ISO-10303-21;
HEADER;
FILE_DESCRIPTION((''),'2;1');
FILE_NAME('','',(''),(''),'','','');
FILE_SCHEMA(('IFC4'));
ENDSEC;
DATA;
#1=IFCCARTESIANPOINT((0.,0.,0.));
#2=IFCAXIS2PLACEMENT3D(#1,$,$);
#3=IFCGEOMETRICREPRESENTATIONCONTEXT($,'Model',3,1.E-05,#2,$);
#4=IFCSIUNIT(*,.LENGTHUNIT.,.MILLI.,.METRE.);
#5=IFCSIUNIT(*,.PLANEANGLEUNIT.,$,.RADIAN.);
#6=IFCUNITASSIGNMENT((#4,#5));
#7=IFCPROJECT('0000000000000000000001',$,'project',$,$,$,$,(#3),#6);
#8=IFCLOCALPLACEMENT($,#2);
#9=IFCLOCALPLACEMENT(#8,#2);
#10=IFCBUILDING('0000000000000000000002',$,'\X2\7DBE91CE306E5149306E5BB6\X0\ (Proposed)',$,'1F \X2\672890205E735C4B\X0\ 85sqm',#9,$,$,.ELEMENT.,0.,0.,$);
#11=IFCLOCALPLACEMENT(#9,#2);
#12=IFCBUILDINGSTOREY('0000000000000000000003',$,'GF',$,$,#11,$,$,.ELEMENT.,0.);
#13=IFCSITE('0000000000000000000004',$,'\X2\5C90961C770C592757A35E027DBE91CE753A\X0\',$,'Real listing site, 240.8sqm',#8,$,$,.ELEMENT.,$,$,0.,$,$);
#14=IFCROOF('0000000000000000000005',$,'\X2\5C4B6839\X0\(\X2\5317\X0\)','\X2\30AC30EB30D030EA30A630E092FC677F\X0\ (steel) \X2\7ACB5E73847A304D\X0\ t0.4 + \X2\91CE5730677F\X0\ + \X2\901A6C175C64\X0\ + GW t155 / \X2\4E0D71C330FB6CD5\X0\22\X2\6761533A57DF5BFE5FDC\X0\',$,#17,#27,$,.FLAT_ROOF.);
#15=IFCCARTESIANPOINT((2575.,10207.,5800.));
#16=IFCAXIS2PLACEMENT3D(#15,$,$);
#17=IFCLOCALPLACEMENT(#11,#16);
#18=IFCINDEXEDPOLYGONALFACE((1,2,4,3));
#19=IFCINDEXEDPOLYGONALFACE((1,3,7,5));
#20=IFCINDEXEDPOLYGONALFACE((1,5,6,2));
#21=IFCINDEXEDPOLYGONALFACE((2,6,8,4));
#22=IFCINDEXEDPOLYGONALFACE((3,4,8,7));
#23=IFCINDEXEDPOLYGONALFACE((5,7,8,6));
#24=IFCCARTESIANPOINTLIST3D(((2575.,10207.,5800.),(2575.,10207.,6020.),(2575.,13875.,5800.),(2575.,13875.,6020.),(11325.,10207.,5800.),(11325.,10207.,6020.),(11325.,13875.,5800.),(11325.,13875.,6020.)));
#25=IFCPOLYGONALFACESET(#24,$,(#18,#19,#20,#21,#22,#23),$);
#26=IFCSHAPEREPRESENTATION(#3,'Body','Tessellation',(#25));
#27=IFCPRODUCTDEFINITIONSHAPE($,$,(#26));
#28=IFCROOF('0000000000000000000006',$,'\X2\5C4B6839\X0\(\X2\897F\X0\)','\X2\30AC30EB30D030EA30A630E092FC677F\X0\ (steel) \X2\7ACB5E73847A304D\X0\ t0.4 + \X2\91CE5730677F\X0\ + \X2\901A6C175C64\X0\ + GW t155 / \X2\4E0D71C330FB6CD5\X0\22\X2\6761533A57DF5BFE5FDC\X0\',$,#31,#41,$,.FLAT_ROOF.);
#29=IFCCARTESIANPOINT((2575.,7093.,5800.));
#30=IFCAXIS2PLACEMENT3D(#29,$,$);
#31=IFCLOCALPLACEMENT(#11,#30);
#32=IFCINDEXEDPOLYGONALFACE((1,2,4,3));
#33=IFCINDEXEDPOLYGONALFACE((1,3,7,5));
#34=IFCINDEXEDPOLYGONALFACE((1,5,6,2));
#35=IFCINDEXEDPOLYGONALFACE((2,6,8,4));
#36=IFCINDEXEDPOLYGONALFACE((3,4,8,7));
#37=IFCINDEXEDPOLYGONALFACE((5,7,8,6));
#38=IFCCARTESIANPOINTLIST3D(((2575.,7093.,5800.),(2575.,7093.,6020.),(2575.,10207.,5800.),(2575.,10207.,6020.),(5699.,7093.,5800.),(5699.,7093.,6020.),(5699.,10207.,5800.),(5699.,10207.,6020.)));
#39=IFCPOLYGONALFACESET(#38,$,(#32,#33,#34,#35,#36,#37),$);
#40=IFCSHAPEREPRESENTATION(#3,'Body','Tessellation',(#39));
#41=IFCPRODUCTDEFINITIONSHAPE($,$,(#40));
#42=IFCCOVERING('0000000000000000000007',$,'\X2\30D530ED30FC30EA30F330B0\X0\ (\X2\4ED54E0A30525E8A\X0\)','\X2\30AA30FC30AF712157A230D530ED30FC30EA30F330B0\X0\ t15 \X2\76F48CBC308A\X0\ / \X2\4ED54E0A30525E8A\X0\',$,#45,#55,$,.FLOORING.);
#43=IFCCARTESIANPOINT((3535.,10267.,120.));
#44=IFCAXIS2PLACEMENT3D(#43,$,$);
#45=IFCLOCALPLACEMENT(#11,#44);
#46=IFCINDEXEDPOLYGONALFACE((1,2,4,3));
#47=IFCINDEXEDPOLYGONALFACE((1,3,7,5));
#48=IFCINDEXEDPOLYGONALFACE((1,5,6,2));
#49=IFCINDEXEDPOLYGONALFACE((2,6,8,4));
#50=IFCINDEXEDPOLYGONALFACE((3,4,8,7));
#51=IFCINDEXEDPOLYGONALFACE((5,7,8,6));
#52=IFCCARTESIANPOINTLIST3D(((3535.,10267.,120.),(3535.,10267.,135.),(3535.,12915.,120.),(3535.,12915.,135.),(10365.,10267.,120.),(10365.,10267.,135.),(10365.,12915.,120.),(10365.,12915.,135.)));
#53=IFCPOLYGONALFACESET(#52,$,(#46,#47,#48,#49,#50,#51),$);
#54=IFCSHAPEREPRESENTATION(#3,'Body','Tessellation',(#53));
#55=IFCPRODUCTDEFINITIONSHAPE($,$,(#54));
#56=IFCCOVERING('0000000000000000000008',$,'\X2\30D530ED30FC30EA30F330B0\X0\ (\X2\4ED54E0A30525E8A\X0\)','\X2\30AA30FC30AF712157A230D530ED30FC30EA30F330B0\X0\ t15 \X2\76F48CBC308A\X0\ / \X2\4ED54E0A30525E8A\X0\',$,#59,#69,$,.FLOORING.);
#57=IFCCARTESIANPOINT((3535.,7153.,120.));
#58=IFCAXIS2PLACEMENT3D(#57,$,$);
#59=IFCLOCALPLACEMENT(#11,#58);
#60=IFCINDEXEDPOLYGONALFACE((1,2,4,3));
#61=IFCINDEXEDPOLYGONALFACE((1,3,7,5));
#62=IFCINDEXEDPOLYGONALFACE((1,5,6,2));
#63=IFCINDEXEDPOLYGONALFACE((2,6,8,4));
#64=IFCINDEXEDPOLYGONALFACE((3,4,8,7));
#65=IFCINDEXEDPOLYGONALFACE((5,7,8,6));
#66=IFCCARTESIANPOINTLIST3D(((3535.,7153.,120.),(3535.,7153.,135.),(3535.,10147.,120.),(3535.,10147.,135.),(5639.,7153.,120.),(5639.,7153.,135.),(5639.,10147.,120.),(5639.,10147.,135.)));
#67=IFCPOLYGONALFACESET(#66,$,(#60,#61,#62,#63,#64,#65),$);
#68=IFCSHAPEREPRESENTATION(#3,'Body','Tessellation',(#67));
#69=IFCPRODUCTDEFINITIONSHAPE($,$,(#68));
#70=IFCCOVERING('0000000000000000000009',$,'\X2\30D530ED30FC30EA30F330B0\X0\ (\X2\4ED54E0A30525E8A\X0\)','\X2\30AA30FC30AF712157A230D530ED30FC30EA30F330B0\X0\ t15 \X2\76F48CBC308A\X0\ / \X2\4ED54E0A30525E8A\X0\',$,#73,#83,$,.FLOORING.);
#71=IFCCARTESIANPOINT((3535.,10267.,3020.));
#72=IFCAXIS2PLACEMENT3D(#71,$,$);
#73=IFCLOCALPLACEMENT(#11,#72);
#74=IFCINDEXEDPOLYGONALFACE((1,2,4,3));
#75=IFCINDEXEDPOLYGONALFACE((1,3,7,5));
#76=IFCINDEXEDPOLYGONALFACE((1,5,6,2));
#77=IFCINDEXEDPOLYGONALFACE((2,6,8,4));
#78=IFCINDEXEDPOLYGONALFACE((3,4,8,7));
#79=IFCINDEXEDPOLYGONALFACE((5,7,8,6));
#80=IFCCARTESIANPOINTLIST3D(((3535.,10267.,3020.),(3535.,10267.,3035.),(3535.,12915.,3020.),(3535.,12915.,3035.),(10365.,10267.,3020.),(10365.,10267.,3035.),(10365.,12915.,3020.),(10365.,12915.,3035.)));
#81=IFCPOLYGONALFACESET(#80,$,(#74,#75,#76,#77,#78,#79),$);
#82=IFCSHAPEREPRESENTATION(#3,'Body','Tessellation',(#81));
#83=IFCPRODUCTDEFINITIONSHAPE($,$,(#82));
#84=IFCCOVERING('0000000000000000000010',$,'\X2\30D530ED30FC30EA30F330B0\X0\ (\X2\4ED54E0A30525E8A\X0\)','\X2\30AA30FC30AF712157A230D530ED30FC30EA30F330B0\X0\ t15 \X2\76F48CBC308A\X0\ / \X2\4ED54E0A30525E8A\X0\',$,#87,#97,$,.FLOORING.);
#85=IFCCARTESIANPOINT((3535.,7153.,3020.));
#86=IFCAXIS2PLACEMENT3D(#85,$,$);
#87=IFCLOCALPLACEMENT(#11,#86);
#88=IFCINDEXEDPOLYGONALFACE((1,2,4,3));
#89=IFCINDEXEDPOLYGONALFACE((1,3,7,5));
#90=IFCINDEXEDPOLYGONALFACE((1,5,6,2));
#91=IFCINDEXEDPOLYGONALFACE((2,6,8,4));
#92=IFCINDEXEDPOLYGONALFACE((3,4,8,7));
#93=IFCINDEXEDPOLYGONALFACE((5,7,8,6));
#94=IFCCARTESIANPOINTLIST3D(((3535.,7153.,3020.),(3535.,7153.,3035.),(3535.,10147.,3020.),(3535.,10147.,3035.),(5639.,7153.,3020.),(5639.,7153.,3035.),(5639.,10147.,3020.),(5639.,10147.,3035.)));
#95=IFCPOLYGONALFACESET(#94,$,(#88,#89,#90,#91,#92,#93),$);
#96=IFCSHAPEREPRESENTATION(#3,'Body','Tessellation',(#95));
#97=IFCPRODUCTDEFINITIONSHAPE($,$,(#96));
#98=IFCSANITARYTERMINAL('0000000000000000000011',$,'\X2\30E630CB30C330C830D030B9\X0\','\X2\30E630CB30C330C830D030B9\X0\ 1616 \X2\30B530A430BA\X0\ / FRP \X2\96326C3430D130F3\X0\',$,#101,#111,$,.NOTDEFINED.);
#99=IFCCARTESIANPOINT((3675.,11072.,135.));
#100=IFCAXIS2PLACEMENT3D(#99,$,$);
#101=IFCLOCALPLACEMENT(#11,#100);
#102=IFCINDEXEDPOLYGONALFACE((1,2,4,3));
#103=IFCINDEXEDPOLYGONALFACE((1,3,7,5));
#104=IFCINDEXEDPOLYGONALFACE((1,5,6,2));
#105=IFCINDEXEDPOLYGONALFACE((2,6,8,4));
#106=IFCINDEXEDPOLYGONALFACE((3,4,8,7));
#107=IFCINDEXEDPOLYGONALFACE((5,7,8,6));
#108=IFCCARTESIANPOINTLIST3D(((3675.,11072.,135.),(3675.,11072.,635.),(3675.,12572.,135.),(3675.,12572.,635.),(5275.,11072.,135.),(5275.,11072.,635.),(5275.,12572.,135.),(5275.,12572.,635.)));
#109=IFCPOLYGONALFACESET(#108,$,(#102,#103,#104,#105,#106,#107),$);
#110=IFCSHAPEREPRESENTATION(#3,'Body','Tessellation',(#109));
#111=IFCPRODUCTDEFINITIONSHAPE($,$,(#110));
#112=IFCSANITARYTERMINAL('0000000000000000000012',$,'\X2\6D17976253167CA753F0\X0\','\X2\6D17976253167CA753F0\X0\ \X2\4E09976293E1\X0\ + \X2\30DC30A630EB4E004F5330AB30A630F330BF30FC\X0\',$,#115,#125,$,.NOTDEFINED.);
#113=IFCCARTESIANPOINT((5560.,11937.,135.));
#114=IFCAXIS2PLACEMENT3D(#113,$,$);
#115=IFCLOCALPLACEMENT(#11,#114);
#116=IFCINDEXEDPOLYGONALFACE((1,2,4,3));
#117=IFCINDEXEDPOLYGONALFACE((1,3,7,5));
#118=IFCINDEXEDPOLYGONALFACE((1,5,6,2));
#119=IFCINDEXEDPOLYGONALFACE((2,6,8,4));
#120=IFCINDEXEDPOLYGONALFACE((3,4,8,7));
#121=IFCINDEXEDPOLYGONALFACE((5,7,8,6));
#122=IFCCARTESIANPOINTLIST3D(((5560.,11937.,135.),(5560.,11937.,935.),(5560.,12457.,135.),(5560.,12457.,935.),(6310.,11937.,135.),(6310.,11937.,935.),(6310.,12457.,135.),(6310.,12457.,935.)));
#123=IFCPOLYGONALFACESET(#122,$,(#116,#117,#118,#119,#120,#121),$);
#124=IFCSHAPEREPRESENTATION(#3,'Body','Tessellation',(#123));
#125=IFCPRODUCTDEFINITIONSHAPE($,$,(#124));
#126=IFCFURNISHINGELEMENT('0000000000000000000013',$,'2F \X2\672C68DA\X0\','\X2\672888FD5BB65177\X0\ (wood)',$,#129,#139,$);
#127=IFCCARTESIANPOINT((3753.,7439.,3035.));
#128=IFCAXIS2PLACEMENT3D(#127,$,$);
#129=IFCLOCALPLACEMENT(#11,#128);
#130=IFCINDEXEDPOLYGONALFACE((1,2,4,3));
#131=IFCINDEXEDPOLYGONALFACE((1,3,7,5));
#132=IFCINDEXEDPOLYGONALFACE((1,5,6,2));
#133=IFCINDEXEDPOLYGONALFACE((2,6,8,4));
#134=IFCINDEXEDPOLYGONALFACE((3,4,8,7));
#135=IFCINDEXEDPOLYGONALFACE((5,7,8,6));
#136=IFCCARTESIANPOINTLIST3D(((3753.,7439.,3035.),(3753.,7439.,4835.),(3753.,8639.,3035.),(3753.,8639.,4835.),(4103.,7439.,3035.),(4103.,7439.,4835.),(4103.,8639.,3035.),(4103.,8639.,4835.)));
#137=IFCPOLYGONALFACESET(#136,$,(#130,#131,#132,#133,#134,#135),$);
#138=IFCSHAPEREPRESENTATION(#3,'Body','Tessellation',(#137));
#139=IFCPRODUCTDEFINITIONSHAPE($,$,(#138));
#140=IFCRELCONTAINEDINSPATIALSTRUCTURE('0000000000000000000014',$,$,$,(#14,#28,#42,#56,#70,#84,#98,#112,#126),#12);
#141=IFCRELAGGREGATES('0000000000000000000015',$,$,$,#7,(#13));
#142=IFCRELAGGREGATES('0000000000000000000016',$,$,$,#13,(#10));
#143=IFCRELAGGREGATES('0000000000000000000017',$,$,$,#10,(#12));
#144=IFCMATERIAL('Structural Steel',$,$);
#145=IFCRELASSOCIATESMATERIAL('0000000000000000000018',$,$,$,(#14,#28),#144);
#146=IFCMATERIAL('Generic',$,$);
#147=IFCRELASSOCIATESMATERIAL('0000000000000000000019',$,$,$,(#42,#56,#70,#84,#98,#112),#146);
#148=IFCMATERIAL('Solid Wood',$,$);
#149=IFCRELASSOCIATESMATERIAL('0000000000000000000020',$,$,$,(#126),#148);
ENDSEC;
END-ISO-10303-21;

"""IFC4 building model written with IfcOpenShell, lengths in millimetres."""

from ifc_helpers import new_model, si_unit, frame, frame_2d, origin, place, context, project, spatial, rectangle, extrude, material, element, save


model = new_model("IFC4")

# Units and contexts
model_context = context("Model", 3, precision=1e-05, world=origin())
ifc_project = project(units=[si_unit("LENGTHUNIT", "METRE", prefix="MILLI"), si_unit("PLANEANGLEUNIT", "RADIAN")], contexts=[model_context])

# Site, building, storey
site_placement = place(None, origin())
site = spatial("IfcSite", under=ifc_project, at=site_placement, Name="岐阜県大垣市綾野町", ObjectType="Real listing site, 240.8sqm", CompositionType="ELEMENT", RefElevation=0.0)
building_placement = place(site_placement, origin())
building = spatial("IfcBuilding", under=site, at=building_placement, Name="綾野の光の家 (Proposed)", ObjectType="1F 木造平屋 85sqm", CompositionType="ELEMENT", ElevationOfRefHeight=0.0, ElevationOfTerrain=0.0)
storey_placement = place(building_placement, origin())
storey = spatial("IfcBuildingStorey", under=building, at=storey_placement, Name="GF", CompositionType="ELEMENT", Elevation=0.0)

# Shared definitions
ifc_material_1 = material(Name="Solid Wood")

# Roofs
ifc_material_2 = material(Name="Structural Steel")
for number, where, name in (
    (1, (2575.0, 10207.0, 5800.0), "屋根(北)"),
):
    element("IfcRoof", number, at=place(storey_placement, frame(where)), inside=storey, material=ifc_material_2, Name=name, Description="ガルバリウム鋼板 (steel) 立平葺き t0.4 + 野地板 + 通気層 + GW t155 / 不燃・法22条区域対応", PredefinedType="FLAT_ROOF", context=model_context, shape_type="SweptSolid", body=[
        extrude(rectangle(XDim=8750.0, YDim=3668.0, at=frame_2d((4375.0, 1834.0))), frame((2575.0, 10207.0, 5800.0)), (0.0, 0.0, 1.0), 220.0),
    ])
roof_placement = place(storey_placement, frame((2575.0, 7093.0, 5800.0)))
element("IfcRoof", 2, at=roof_placement, inside=storey, material=ifc_material_2, Name="屋根(西)", Description="ガルバリウム鋼板 (steel) 立平葺き t0.4 + 野地板 + 通気層 + GW t155 / 不燃・法22条区域対応", PredefinedType="FLAT_ROOF", context=model_context, shape_type="SweptSolid", body=[
    extrude(rectangle(XDim=3124.0, YDim=3114.0, at=frame_2d((1562.0, 1557.0))), frame((2575.0, 7093.0, 5800.0)), (0.0, 0.0, 1.0), 220.0),
])

# Coverings
ifc_material_3 = material(Name="Generic")
covering_1_placement = place(storey_placement, frame((3535.0, 10267.0, 120.0)))
element("IfcCovering", 3, at=covering_1_placement, inside=storey, material=ifc_material_3, Name="フローリング (仕上げ床)", Description="オーク無垢フローリング t15 直貼り / 仕上げ床", PredefinedType="FLOORING", context=model_context, shape_type="SweptSolid", body=[
    extrude(rectangle(XDim=6830.0, YDim=2648.0, at=frame_2d((3415.0, 1324.0))), frame((3535.0, 10267.0, 120.0)), (0.0, 0.0, 1.0), 15.0),
])
covering_2_placement = place(storey_placement, frame((3535.0, 7153.0, 120.0)))
element("IfcCovering", 4, at=covering_2_placement, inside=storey, material=ifc_material_3, Name="フローリング (仕上げ床)", Description="オーク無垢フローリング t15 直貼り / 仕上げ床", PredefinedType="FLOORING", context=model_context, shape_type="SweptSolid", body=[
    extrude(rectangle(XDim=2104.0, YDim=2994.0, at=frame_2d((1052.0, 1497.0))), frame((3535.0, 7153.0, 120.0)), (0.0, 0.0, 1.0), 15.0),
])
covering_3_placement = place(storey_placement, frame((3535.0, 10267.0, 3020.0)))
element("IfcCovering", 5, at=covering_3_placement, inside=storey, material=ifc_material_3, Name="フローリング (仕上げ床)", Description="オーク無垢フローリング t15 直貼り / 仕上げ床", PredefinedType="FLOORING", context=model_context, shape_type="SweptSolid", body=[
    extrude(rectangle(XDim=6830.0, YDim=2648.0, at=frame_2d((3415.0, 1324.0))), frame((3535.0, 10267.0, 3020.0)), (0.0, 0.0, 1.0), 15.0),
])
covering_4_placement = place(storey_placement, frame((3535.0, 7153.0, 3020.0)))
element("IfcCovering", 6, at=covering_4_placement, inside=storey, material=ifc_material_3, Name="フローリング (仕上げ床)", Description="オーク無垢フローリング t15 直貼り / 仕上げ床", PredefinedType="FLOORING", context=model_context, shape_type="SweptSolid", body=[
    extrude(rectangle(XDim=2104.0, YDim=2994.0, at=frame_2d((1052.0, 1497.0))), frame((3535.0, 7153.0, 3020.0)), (0.0, 0.0, 1.0), 15.0),
])

# Sanitary terminals
sanitary_terminal_1_placement = place(storey_placement, frame((3675.0, 11072.0, 135.0)))
element("IfcSanitaryTerminal", 7, at=sanitary_terminal_1_placement, inside=storey, material=ifc_material_3, Name="ユニットバス", Description="ユニットバス 1616 サイズ / FRP 防水パン", PredefinedType="NOTDEFINED", context=model_context, shape_type="SweptSolid", body=[
    extrude(rectangle(XDim=1600.0, YDim=1500.0, at=frame_2d((800.0, 750.0))), frame((3675.0, 11072.0, 135.0)), (0.0, 0.0, 1.0), 500.0),
])
sanitary_terminal_2_placement = place(storey_placement, frame((5560.0, 11937.0, 135.0)))
element("IfcSanitaryTerminal", 8, at=sanitary_terminal_2_placement, inside=storey, material=ifc_material_3, Name="洗面化粧台", Description="洗面化粧台 三面鏡 + ボウル一体カウンター", PredefinedType="NOTDEFINED", context=model_context, shape_type="SweptSolid", body=[
    extrude(rectangle(XDim=750.0, YDim=520.0, at=frame_2d((375.0, 260.0))), frame((5560.0, 11937.0, 135.0)), (0.0, 0.0, 1.0), 800.0),
])

# Furnishing element
furnishing_placement = place(storey_placement, frame((3753.0, 7439.0, 3035.0)))
element("IfcFurnishingElement", 9, at=furnishing_placement, inside=storey, material=ifc_material_1, Name="2F 本棚", Description="木製家具 (wood)", context=model_context, shape_type="SweptSolid", body=[
    extrude(rectangle(XDim=350.0, YDim=1200.0, at=frame_2d((175.0, 600.0))), frame((3753.0, 7439.0, 3035.0)), (0.0, 0.0, 1.0), 1800.0),
])

save(model, "model.ifc")
